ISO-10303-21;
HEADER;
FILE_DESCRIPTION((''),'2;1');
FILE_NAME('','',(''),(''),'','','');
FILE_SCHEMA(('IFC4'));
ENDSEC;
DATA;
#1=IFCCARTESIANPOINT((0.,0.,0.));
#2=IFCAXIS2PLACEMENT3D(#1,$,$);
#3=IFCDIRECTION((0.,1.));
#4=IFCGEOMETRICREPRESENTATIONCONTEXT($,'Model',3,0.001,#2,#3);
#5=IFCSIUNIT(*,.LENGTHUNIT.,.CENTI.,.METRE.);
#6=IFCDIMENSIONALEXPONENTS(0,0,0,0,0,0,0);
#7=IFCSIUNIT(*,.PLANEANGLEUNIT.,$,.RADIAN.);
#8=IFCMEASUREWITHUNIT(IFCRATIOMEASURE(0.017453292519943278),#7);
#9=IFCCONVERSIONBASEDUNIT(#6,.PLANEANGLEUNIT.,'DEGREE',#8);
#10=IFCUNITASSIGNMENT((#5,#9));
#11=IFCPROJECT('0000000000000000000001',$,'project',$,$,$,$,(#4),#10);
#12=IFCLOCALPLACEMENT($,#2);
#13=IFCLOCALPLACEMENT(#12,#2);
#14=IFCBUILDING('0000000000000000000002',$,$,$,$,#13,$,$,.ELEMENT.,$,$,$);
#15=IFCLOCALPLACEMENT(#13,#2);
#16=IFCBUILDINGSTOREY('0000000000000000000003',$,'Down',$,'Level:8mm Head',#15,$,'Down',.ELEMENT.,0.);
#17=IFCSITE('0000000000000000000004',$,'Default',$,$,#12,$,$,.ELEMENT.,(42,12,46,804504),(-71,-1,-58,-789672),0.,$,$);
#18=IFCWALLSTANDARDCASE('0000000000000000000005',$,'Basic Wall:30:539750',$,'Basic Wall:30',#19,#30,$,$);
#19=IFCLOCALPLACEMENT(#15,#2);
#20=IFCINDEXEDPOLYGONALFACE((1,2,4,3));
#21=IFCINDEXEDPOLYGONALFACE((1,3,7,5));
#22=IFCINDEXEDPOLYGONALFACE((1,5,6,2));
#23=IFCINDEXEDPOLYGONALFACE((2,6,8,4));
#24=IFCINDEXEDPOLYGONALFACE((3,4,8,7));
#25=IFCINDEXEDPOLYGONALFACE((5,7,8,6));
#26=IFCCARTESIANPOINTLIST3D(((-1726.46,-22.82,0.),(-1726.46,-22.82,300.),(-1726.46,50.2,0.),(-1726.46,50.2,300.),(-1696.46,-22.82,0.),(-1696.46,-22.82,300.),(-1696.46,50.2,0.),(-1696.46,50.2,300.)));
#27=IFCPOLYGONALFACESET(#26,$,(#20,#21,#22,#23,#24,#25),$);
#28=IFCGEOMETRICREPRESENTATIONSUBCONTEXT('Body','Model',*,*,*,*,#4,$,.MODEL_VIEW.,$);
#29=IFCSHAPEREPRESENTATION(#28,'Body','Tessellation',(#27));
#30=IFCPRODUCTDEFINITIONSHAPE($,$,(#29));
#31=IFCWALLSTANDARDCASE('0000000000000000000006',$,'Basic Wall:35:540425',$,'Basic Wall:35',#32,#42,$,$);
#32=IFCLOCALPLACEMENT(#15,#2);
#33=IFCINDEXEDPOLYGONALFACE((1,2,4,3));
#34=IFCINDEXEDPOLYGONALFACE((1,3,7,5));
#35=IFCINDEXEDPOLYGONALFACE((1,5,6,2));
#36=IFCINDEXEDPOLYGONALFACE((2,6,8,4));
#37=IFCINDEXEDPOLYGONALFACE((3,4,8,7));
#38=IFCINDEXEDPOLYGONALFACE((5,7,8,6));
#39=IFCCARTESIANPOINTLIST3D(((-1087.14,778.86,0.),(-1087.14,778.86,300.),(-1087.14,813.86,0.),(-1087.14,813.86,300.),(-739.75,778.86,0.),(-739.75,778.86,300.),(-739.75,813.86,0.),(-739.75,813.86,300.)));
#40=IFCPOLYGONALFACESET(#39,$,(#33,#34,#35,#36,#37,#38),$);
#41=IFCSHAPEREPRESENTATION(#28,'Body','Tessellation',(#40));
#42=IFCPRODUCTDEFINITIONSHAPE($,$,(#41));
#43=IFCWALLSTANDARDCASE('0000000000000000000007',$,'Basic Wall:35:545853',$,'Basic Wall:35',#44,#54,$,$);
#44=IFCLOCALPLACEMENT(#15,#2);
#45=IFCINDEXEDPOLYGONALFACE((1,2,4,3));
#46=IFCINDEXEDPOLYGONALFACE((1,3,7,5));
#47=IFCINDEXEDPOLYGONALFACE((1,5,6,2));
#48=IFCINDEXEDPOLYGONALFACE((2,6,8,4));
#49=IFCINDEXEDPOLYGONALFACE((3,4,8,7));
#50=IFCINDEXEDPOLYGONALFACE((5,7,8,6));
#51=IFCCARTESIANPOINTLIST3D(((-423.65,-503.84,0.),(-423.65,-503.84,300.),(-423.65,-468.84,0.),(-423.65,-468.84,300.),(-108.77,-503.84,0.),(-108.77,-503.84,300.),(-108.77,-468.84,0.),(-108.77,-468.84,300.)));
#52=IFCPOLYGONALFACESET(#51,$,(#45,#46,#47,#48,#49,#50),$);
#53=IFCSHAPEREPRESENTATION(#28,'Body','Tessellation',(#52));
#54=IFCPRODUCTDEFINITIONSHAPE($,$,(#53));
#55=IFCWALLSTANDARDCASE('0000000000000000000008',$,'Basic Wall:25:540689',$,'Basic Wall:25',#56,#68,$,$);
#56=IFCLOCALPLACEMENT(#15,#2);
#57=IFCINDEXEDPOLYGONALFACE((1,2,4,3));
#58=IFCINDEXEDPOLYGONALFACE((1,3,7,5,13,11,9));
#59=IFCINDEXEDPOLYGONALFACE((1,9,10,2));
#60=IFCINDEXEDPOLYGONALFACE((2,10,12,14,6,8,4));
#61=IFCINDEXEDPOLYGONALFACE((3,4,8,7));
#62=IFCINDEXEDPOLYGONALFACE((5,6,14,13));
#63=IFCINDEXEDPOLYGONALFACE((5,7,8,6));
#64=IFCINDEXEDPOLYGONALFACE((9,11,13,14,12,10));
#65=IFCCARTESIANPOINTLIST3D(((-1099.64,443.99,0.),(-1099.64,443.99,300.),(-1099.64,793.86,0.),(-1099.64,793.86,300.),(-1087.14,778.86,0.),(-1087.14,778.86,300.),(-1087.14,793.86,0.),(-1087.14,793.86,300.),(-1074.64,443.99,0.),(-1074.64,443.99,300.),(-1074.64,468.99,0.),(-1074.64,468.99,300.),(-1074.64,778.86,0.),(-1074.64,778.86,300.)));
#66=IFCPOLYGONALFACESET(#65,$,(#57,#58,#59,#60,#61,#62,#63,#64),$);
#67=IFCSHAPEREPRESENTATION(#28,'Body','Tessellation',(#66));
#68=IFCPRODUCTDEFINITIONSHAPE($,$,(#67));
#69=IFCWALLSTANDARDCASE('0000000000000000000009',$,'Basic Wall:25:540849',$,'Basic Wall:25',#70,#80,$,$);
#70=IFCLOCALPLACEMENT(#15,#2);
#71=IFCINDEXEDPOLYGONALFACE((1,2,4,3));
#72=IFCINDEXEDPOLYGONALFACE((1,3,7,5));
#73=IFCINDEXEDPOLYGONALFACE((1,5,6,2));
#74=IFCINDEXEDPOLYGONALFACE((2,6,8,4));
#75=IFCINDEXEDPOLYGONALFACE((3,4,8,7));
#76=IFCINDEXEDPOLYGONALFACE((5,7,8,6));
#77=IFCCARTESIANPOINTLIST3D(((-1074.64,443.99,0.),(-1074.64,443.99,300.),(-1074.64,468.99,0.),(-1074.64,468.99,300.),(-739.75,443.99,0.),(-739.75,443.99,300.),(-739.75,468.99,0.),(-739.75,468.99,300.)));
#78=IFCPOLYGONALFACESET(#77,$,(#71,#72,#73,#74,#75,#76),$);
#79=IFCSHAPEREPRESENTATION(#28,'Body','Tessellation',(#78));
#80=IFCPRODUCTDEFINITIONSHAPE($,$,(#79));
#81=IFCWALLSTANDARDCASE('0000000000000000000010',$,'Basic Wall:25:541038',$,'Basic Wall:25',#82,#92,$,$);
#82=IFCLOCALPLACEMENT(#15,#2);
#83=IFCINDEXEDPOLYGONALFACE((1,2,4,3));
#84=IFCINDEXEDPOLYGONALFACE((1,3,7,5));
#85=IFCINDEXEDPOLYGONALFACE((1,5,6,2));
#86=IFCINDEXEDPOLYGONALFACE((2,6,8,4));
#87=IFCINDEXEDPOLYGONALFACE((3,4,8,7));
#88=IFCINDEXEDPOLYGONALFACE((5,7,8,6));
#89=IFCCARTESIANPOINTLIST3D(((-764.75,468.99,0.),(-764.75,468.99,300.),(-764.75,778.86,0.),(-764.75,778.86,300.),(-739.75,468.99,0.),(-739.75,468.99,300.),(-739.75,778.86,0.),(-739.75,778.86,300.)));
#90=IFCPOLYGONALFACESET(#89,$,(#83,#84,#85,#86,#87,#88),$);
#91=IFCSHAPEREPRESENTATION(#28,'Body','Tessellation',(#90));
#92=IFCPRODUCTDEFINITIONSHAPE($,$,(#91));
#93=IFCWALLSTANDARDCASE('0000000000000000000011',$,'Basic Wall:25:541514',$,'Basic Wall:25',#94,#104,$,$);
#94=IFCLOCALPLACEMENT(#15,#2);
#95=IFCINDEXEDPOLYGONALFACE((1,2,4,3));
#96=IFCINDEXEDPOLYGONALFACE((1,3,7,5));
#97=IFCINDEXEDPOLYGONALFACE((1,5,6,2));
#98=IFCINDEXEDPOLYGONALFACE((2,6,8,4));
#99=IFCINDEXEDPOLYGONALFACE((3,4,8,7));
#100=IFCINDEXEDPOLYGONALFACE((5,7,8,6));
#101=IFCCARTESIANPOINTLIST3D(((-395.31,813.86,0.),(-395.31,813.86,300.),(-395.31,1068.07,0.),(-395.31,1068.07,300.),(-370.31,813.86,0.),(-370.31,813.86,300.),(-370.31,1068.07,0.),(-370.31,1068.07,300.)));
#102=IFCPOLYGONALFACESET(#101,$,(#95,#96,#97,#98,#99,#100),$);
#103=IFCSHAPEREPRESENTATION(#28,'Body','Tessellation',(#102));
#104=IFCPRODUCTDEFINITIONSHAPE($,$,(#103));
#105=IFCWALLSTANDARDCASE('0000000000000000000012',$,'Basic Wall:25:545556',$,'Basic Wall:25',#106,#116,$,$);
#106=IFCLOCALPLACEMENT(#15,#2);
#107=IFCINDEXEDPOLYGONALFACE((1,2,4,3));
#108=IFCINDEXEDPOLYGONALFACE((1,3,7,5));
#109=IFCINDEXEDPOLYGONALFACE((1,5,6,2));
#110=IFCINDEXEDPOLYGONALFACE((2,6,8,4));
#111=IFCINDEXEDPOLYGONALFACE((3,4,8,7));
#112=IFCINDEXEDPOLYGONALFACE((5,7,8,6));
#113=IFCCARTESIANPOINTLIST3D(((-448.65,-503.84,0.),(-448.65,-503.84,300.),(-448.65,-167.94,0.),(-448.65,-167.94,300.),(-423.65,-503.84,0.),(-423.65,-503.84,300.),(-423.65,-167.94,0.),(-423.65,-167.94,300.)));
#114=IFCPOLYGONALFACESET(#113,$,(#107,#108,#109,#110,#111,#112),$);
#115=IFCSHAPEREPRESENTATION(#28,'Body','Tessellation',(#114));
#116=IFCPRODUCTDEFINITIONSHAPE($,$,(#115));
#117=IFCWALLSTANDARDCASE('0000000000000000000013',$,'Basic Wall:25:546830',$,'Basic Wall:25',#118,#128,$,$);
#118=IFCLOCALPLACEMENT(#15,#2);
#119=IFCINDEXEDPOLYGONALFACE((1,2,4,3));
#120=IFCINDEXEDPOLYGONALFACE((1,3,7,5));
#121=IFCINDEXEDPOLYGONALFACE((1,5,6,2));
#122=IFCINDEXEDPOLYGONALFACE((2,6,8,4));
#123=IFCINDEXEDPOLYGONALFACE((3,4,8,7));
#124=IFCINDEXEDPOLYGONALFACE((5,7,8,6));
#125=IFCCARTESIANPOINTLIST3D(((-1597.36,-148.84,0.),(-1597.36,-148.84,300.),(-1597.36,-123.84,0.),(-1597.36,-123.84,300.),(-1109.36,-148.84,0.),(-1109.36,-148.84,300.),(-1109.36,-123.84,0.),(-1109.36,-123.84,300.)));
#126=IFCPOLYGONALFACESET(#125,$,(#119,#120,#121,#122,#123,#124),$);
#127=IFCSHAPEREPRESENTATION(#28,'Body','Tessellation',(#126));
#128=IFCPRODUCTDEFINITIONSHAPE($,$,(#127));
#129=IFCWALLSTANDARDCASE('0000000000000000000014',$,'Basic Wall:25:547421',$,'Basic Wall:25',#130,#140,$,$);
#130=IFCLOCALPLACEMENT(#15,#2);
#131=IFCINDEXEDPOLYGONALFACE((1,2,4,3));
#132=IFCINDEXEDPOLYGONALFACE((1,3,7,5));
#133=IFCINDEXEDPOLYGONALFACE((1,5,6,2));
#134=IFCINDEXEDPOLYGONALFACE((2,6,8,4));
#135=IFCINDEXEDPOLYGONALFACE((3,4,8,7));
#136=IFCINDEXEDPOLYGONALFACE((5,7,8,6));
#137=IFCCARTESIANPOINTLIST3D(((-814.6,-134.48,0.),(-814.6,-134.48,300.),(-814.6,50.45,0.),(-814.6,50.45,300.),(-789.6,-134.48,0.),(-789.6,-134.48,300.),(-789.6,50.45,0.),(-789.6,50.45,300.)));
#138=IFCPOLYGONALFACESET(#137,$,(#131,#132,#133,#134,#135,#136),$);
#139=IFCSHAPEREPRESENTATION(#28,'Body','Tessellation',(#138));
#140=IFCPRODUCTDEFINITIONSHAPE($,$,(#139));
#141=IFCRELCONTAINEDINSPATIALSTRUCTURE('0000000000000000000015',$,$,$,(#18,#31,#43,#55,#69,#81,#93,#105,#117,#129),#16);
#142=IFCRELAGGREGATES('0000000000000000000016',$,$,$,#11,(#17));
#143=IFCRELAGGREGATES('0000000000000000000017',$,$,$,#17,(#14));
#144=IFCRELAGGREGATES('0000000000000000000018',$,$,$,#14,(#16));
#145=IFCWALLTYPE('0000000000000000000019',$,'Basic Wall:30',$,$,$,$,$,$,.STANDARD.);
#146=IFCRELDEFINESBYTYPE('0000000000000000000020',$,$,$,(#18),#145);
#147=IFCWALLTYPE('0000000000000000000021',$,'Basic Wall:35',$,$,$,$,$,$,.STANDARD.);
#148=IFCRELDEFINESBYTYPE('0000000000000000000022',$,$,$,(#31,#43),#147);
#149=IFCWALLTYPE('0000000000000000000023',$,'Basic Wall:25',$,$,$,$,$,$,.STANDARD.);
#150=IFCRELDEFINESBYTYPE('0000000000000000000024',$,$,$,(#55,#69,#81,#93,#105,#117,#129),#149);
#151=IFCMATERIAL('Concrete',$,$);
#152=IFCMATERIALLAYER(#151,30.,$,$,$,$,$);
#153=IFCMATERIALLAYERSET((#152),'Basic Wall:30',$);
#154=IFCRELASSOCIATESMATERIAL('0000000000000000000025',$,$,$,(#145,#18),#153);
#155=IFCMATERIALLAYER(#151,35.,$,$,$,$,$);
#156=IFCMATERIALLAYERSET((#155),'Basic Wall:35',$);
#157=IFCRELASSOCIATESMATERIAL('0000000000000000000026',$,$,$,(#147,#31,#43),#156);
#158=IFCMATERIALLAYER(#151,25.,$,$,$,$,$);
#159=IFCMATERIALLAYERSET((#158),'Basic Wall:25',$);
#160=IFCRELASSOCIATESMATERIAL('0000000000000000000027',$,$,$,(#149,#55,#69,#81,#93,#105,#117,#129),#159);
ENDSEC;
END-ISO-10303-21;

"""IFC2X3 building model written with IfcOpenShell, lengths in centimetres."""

from ifc_helpers import new_model, entity, si_unit, converted_unit, direction, frame, frame_2d, origin, place, context, subcontext, project, spatial, polyline, rectangle, outline, extrude, material, layer, layer_set, layer_usage, type_object, element, save


model = new_model("IFC2X3")

# Units and contexts
model_context = context("Model", 3, precision=0.001, world=origin(), true_north=direction((0.0, 1.0)))
body_context = subcontext(model_context, "Body", "Model", "MODEL_VIEW")
ifc_project = project(units=[si_unit("LENGTHUNIT", "METRE", prefix="CENTI"), converted_unit("PLANEANGLEUNIT", "DEGREE", entity("IfcRatioMeasure", 0.017453292519943278), si_unit("PLANEANGLEUNIT", "RADIAN"), dimensions=[0, 0, 0, 0, 0, 0, 0])], contexts=[model_context])

# Site, building, storey
site_placement = place(None, origin())
site = spatial("IfcSite", under=ifc_project, at=site_placement, Name="Default", CompositionType="ELEMENT", RefLatitude=(42, 12, 46, 804504), RefLongitude=(-71, -1, -58, -789672), RefElevation=0.0)
building_placement = place(site_placement, origin())
building = spatial("IfcBuilding", under=site, at=building_placement, CompositionType="ELEMENT")
storey_placement = place(building_placement, origin())
storey = spatial("IfcBuildingStorey", under=building, at=storey_placement, Name="Down", ObjectType="Level:8mm Head", LongName="Down", CompositionType="ELEMENT", Elevation=0.0)

# Walls
ifc_material = material(Name="Concrete")
ifc_layer_1 = layer(ifc_material, 30.0)
ifc_layer_set_1 = layer_set([ifc_layer_1], Name="Basic Wall:30")
ifc_layer_usage_1 = layer_usage(ifc_layer_set_1, "AXIS2", "POSITIVE", -15.0)
wall_type_1 = type_object("IfcWallType", Name="Basic Wall:30", PredefinedType="STANDARD", material=ifc_layer_set_1)
wall_1_placement = place(storey_placement, frame((-1711.46, 50.2, 0.0), z_axis=(0.0, 0.0, 1.0), x_axis=(0.0, -1.0, 0.0)))
element("IfcWallStandardCase", 1, at=wall_1_placement, inside=storey, type_object=wall_type_1, material=ifc_layer_usage_1, Name="Basic Wall:30:539750", ObjectType="Basic Wall:30", context=body_context, shape_type="SweptSolid", body=[
    extrude(rectangle(XDim=73.02, YDim=30.0, at=frame_2d((36.51, 0.0), x_axis=(-1.0, 0.0))), origin(), (0.0, 0.0, 1.0), 300.0),
])
ifc_layer_2 = layer(ifc_material, 35.0)
ifc_layer_set_2 = layer_set([ifc_layer_2], Name="Basic Wall:35")
ifc_layer_usage_2 = layer_usage(ifc_layer_set_2, "AXIS2", "NEGATIVE", 17.5)
wall_type_2 = type_object("IfcWallType", Name="Basic Wall:35", PredefinedType="STANDARD", material=ifc_layer_set_2)
wall_2_placement = place(storey_placement, frame((-1087.14, 796.36, 0.0)))
element("IfcWallStandardCase", 2, at=wall_2_placement, inside=storey, type_object=wall_type_2, material=ifc_layer_usage_2, Name="Basic Wall:35:540425", ObjectType="Basic Wall:35", context=body_context, shape_type="SweptSolid", body=[
    extrude(rectangle(XDim=347.39, YDim=35.0, at=frame_2d((173.69, 0.0), x_axis=(-1.0, 0.0))), origin(), (0.0, 0.0, 1.0), 300.0),
])
ifc_layer_usage_3 = layer_usage(ifc_layer_set_2, "AXIS2", "NEGATIVE", 17.5)
wall_3_placement = place(storey_placement, frame((-108.77, -486.34, 0.0), z_axis=(0.0, 0.0, 1.0), x_axis=(-1.0, 0.0, 0.0)))
element("IfcWallStandardCase", 3, at=wall_3_placement, inside=storey, type_object=wall_type_2, material=ifc_layer_usage_3, Name="Basic Wall:35:545853", ObjectType="Basic Wall:35", context=body_context, shape_type="SweptSolid", body=[
    extrude(rectangle(XDim=314.88, YDim=35.0, at=frame_2d((157.44, 0.0), x_axis=(-1.0, 0.0))), origin(), (0.0, 0.0, 1.0), 300.0),
])
ifc_layer_3 = layer(ifc_material, 25.0)
ifc_layer_set_3 = layer_set([ifc_layer_3], Name="Basic Wall:25")
ifc_layer_usage_4 = layer_usage(ifc_layer_set_3, "AXIS2", "POSITIVE", -12.5)
wall_type_3 = type_object("IfcWallType", Name="Basic Wall:25", PredefinedType="STANDARD", material=ifc_layer_set_3)
wall_4_placement = place(storey_placement, frame((-1087.14, 793.86, 0.0), z_axis=(0.0, 0.0, 1.0), x_axis=(0.0, -1.0, 0.0)))
element("IfcWallStandardCase", 4, at=wall_4_placement, inside=storey, type_object=wall_type_3, material=ifc_layer_usage_4, Name="Basic Wall:25:540689", ObjectType="Basic Wall:25", context=body_context, shape_type="SweptSolid", body=[
    extrude(outline(polyline([(349.87, -12.5), (349.87, 12.5), (324.87, 12.5), (15.0, 12.5), (15.0, 0.0), (0.0, 0.0), (0.0, -12.5), (349.87, -12.5)])), origin(), (0.0, 0.0, 1.0), 300.0),
])
ifc_layer_usage_5 = layer_usage(ifc_layer_set_3, "AXIS2", "POSITIVE", -12.5)
wall_5_placement = place(storey_placement, frame((-1074.64, 456.49, 0.0)))
element("IfcWallStandardCase", 5, at=wall_5_placement, inside=storey, type_object=wall_type_3, material=ifc_layer_usage_5, Name="Basic Wall:25:540849", ObjectType="Basic Wall:25", context=body_context, shape_type="SweptSolid", body=[
    extrude(rectangle(XDim=334.89, YDim=25.0, at=frame_2d((167.44, 0.0), x_axis=(-1.0, 0.0))), origin(), (0.0, 0.0, 1.0), 300.0),
])
ifc_layer_usage_6 = layer_usage(ifc_layer_set_3, "AXIS2", "POSITIVE", -12.5)
wall_6_placement = place(storey_placement, frame((-752.25, 468.99, 0.0), z_axis=(0.0, 0.0, 1.0), x_axis=(0.0, 1.0, 0.0)))
element("IfcWallStandardCase", 6, at=wall_6_placement, inside=storey, type_object=wall_type_3, material=ifc_layer_usage_6, Name="Basic Wall:25:541038", ObjectType="Basic Wall:25", context=body_context, shape_type="SweptSolid", body=[
    extrude(rectangle(XDim=309.87, YDim=25.0, at=frame_2d((154.93, 0.0), x_axis=(-1.0, 0.0))), origin(), (0.0, 0.0, 1.0), 300.0),
])
ifc_layer_usage_7 = layer_usage(ifc_layer_set_3, "AXIS2", "NEGATIVE", 12.5)
wall_7_placement = place(storey_placement, frame((-382.81, 813.86, 0.0), z_axis=(0.0, 0.0, 1.0), x_axis=(0.0, 1.0, 0.0)))
element("IfcWallStandardCase", 7, at=wall_7_placement, inside=storey, type_object=wall_type_3, material=ifc_layer_usage_7, Name="Basic Wall:25:541514", ObjectType="Basic Wall:25", context=body_context, shape_type="SweptSolid", body=[
    extrude(rectangle(XDim=254.21, YDim=25.0, at=frame_2d((127.11, 0.0), x_axis=(-1.0, 0.0))), origin(), (0.0, 0.0, 1.0), 300.0),
])
ifc_layer_usage_8 = layer_usage(ifc_layer_set_3, "AXIS2", "POSITIVE", -12.5)
wall_8_placement = place(storey_placement, frame((-436.15, -167.94, 0.0), z_axis=(0.0, 0.0, 1.0), x_axis=(0.0, -1.0, 0.0)))
element("IfcWallStandardCase", 8, at=wall_8_placement, inside=storey, type_object=wall_type_3, material=ifc_layer_usage_8, Name="Basic Wall:25:545556", ObjectType="Basic Wall:25", context=body_context, shape_type="SweptSolid", body=[
    extrude(rectangle(XDim=335.91, YDim=25.0, at=frame_2d((167.95, 0.0), x_axis=(-1.0, 0.0))), origin(), (0.0, 0.0, 1.0), 300.0),
])
ifc_layer_usage_9 = layer_usage(ifc_layer_set_3, "AXIS2", "POSITIVE", -12.5)
wall_9_placement = place(storey_placement, frame((-1109.36, -136.34, 0.0), z_axis=(0.0, 0.0, 1.0), x_axis=(-1.0, 0.0, 0.0)))
element("IfcWallStandardCase", 9, at=wall_9_placement, inside=storey, type_object=wall_type_3, material=ifc_layer_usage_9, Name="Basic Wall:25:546830", ObjectType="Basic Wall:25", context=body_context, shape_type="SweptSolid", body=[
    extrude(rectangle(XDim=488.0, YDim=25.0, at=frame_2d((244.0, 0.0), x_axis=(-1.0, 0.0))), origin(), (0.0, 0.0, 1.0), 300.0),
])
ifc_layer_usage_10 = layer_usage(ifc_layer_set_3, "AXIS2", "POSITIVE", -12.5)
wall_10_placement = place(storey_placement, frame((-802.1, -134.48, 0.0), z_axis=(0.0, 0.0, 1.0), x_axis=(0.0, 1.0, 0.0)))
element("IfcWallStandardCase", 10, at=wall_10_placement, inside=storey, type_object=wall_type_3, material=ifc_layer_usage_10, Name="Basic Wall:25:547421", ObjectType="Basic Wall:25", context=body_context, shape_type="SweptSolid", body=[
    extrude(rectangle(XDim=184.93, YDim=25.0, at=frame_2d((92.46, 0.0), x_axis=(-1.0, 0.0))), origin(), (0.0, 0.0, 1.0), 300.0),
])

save(model, "model.ifc")
